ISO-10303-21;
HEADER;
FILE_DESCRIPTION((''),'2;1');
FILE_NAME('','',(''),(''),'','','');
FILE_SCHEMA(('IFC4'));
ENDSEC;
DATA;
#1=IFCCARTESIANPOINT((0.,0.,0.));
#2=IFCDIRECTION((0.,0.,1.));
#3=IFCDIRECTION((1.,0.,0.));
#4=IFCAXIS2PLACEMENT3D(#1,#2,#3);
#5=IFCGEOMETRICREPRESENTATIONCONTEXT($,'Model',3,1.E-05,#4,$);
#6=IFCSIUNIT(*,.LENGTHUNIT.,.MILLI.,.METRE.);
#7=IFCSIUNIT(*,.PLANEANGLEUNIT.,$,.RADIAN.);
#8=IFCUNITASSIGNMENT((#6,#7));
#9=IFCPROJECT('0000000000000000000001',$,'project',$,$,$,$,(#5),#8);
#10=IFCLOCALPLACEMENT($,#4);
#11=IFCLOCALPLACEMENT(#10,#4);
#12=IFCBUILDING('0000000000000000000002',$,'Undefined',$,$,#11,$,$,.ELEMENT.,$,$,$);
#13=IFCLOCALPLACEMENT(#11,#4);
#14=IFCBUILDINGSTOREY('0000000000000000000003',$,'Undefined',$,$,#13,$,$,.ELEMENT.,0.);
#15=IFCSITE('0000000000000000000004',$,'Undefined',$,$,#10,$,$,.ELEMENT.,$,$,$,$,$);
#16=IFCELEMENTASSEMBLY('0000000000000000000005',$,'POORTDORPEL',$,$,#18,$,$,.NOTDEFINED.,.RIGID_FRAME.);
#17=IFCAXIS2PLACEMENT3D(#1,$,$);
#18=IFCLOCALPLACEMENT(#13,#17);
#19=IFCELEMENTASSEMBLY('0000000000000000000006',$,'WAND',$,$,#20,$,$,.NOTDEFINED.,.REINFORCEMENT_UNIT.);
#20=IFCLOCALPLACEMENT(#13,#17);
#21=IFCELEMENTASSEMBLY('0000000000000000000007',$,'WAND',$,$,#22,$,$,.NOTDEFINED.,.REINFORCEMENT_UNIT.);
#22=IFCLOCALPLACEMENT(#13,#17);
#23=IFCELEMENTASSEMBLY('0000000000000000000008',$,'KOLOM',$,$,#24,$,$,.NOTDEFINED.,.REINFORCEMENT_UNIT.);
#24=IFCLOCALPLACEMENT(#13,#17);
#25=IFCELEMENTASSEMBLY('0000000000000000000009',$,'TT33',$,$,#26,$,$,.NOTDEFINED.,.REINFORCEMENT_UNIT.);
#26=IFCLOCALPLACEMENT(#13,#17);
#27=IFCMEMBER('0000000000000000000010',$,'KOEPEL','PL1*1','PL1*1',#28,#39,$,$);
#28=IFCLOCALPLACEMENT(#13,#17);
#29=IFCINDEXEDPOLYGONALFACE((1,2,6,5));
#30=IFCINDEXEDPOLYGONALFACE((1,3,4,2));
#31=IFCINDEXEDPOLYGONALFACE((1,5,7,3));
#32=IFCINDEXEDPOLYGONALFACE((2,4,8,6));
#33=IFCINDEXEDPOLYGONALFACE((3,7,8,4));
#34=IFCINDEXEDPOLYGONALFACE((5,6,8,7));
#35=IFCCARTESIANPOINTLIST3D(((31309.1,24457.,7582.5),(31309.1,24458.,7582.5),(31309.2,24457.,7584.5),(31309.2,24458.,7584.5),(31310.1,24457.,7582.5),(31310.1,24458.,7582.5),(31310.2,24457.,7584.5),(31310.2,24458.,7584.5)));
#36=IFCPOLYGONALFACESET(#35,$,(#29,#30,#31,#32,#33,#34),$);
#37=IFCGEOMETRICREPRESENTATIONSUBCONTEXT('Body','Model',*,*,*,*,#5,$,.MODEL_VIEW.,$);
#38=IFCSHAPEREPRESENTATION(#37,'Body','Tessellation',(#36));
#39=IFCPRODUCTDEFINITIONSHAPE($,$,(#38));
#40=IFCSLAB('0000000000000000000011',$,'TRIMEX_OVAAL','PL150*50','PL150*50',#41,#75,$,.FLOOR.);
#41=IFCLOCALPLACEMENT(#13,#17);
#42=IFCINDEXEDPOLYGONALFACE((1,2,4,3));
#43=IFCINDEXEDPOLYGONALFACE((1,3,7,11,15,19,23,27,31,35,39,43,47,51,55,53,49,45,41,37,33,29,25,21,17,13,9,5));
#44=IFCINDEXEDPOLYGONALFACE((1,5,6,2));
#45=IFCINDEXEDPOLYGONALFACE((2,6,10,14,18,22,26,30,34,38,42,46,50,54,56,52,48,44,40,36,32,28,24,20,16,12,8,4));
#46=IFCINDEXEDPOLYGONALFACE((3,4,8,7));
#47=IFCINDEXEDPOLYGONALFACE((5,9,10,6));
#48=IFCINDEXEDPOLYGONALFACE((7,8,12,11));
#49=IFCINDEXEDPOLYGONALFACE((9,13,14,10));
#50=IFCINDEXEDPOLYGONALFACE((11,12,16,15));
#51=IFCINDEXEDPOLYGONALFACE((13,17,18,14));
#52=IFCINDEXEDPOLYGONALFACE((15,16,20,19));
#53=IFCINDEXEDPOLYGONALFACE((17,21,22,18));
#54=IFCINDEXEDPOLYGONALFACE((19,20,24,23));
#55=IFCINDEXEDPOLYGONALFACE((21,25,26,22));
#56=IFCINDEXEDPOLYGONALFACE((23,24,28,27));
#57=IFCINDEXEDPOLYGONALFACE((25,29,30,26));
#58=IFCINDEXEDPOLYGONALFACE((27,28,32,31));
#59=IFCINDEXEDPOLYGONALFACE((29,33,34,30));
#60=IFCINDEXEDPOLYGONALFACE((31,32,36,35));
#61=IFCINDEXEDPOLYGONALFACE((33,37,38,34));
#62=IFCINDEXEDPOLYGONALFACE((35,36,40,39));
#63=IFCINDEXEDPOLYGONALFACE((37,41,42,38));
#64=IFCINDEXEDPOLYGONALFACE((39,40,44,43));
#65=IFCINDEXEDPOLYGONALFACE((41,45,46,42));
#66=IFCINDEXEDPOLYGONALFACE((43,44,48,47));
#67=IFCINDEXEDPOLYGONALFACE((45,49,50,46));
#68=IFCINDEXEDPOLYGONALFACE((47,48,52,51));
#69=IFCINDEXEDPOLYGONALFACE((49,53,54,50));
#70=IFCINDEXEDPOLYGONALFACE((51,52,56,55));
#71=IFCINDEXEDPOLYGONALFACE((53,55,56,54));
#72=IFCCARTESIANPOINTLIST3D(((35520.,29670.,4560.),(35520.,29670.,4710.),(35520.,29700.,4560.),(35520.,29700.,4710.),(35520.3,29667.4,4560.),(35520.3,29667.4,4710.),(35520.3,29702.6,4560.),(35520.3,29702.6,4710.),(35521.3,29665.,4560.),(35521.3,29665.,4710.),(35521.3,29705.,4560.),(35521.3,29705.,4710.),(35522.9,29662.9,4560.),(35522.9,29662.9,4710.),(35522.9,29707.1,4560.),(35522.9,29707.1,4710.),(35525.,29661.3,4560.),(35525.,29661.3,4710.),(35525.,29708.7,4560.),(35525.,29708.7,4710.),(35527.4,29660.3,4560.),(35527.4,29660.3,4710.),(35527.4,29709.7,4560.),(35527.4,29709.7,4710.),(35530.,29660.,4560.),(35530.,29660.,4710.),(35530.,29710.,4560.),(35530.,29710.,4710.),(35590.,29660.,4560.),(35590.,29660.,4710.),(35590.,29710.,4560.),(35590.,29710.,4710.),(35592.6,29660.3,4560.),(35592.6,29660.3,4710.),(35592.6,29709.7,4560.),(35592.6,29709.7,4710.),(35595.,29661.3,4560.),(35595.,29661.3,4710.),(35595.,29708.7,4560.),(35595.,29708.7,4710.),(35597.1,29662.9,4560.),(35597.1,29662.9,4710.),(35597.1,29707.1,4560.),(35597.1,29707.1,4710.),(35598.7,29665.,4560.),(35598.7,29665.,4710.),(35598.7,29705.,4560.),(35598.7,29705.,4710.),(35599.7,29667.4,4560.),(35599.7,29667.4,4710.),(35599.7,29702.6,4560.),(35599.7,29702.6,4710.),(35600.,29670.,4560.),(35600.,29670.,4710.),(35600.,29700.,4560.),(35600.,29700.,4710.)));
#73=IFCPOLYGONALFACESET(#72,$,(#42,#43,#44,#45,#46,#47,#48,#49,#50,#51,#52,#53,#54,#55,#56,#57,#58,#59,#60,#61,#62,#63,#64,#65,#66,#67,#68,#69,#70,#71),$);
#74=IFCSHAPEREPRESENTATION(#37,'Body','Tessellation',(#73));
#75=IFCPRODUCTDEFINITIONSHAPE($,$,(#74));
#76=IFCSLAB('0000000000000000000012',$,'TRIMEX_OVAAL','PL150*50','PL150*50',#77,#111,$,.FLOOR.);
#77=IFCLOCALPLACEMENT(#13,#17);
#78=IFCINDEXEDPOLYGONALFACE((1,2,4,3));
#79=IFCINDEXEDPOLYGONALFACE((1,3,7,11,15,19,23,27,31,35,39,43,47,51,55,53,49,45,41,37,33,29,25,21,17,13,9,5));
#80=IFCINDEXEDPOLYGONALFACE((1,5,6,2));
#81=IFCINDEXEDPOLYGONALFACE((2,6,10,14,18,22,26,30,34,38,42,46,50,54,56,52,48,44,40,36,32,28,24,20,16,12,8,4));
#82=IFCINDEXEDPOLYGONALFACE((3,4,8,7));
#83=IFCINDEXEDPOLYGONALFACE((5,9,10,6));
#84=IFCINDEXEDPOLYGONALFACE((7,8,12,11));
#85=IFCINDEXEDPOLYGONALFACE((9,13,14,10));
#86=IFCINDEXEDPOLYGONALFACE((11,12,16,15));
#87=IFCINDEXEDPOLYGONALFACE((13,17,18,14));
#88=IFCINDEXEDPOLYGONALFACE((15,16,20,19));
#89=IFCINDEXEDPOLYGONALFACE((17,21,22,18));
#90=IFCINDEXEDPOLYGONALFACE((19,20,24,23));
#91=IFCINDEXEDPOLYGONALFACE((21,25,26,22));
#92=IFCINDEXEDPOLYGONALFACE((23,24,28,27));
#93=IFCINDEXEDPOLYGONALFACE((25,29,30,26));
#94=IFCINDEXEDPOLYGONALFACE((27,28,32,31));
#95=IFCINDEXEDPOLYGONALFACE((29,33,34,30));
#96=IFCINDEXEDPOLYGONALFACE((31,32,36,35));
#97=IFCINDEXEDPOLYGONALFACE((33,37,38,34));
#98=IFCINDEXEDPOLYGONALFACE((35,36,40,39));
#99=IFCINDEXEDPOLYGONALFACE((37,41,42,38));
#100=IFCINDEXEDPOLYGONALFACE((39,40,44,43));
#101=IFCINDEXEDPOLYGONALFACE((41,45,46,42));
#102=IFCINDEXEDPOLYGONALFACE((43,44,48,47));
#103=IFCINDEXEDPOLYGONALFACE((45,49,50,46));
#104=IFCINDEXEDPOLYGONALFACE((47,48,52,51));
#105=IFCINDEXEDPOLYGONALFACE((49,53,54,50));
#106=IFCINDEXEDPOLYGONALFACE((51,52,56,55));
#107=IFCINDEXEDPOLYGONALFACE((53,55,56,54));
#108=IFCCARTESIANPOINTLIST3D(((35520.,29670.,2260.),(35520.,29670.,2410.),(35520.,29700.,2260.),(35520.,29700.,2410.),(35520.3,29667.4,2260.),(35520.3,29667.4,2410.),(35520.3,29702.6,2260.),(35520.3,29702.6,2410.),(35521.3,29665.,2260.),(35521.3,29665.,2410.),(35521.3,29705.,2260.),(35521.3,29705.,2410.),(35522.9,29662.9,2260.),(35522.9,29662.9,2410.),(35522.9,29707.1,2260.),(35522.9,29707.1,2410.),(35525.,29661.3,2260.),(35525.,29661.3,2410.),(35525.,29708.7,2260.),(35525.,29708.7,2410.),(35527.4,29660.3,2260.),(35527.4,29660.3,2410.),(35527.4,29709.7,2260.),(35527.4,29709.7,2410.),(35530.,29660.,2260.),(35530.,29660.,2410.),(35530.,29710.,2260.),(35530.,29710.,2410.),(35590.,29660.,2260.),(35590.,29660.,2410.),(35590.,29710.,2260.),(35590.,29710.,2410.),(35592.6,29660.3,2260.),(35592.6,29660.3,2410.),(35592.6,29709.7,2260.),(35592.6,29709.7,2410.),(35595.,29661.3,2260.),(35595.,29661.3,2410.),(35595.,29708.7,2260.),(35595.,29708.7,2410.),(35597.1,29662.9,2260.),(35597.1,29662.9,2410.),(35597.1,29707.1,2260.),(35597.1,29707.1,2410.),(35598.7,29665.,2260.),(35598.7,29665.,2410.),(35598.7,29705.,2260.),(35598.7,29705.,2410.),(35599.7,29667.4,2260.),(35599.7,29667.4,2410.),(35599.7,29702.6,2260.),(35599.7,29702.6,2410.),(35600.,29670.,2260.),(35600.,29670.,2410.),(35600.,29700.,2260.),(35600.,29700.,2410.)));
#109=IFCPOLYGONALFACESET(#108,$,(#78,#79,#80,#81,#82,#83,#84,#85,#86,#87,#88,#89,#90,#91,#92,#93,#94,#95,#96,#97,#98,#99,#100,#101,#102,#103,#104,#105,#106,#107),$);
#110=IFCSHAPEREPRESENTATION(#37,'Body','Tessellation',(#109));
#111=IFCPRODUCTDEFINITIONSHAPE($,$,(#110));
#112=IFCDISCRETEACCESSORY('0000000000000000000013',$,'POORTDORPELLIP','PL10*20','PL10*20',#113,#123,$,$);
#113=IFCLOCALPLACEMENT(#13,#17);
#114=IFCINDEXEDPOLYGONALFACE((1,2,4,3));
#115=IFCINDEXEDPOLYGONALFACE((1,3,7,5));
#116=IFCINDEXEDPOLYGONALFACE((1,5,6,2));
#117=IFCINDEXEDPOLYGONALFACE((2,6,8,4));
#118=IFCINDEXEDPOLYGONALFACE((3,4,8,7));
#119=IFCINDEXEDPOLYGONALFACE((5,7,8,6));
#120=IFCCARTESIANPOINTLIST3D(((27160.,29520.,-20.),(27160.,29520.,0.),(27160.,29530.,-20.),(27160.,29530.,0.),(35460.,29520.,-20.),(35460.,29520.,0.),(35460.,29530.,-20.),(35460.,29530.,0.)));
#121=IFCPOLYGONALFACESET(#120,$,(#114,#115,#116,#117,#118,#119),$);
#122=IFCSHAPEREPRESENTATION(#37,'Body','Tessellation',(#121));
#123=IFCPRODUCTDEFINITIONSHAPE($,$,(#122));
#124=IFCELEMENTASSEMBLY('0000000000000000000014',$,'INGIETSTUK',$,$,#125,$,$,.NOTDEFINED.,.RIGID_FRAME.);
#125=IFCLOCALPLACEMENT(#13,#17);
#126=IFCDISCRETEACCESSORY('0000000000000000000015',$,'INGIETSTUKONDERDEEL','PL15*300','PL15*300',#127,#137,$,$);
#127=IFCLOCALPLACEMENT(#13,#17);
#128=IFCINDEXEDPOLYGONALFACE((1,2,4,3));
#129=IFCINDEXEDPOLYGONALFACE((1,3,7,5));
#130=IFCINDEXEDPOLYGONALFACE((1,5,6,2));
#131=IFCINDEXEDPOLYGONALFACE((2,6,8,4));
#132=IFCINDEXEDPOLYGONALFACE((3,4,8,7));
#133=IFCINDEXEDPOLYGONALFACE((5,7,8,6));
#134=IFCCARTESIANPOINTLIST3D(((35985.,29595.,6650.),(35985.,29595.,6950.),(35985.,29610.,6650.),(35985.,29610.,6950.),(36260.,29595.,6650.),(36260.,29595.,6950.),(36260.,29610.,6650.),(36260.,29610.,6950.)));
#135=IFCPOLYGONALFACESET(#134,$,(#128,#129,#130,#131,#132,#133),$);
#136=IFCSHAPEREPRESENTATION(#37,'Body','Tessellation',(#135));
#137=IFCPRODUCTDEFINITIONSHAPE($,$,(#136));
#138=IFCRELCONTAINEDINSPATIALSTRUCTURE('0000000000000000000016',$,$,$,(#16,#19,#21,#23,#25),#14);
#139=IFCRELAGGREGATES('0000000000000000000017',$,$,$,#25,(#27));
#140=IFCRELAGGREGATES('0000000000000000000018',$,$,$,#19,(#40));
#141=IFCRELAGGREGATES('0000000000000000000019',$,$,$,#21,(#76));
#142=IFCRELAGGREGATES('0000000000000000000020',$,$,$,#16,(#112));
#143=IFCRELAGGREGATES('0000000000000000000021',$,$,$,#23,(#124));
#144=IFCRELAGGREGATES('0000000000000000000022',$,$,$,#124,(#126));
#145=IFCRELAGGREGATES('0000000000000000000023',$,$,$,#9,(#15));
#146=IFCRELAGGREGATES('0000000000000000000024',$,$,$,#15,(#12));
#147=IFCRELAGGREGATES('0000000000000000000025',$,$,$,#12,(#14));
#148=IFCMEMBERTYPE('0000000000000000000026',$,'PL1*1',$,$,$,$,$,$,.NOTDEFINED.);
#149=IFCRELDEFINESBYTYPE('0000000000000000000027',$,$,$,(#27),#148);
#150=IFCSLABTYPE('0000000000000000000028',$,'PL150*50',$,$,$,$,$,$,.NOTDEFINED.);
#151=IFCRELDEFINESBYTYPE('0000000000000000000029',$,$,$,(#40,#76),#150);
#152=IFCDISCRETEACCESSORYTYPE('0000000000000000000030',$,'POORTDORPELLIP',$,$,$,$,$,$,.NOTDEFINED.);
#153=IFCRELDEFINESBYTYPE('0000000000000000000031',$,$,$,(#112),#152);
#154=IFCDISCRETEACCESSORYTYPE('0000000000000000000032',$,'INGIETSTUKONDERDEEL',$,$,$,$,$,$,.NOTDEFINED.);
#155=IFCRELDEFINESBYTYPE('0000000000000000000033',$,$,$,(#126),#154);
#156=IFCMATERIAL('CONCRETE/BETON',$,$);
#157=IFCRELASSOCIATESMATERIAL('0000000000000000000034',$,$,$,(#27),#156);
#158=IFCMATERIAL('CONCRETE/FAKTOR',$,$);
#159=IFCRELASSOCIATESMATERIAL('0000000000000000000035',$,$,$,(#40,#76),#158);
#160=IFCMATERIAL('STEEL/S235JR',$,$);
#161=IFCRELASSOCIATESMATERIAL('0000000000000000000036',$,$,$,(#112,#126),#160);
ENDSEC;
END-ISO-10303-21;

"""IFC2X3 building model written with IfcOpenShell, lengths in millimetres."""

from ifc_helpers import new_model, si_unit, frame, frame_2d, origin_with_axes, place, context, subcontext, project, spatial, polyline, circle_curve, parameter, trimmed, segment, composite_curve, rectangle, outline, extrude, material, type_object, element, aggregate, save


model = new_model("IFC2X3")

# Units and contexts
model_context = context("Model", 3, precision=1e-05, world=origin_with_axes())
body_context = subcontext(model_context, "Body", "Model", "MODEL_VIEW")
ifc_project = project(units=[si_unit("LENGTHUNIT", "METRE", prefix="MILLI"), si_unit("PLANEANGLEUNIT", "RADIAN")], contexts=[model_context])

# Site, building, storey
site_placement = place(None, origin_with_axes())
site = spatial("IfcSite", under=ifc_project, at=site_placement, Name="Undefined", CompositionType="ELEMENT")
building_placement = place(site_placement, origin_with_axes())
building = spatial("IfcBuilding", under=site, at=building_placement, Name="Undefined", CompositionType="ELEMENT")
storey_placement = place(building_placement, origin_with_axes())
storey = spatial("IfcBuildingStorey", under=building, at=storey_placement, Name="Undefined", CompositionType="ELEMENT", Elevation=0.0)

# Element assembly
assembly_1_placement = place(storey_placement, origin_with_axes())
assembly_1 = element("IfcElementAssembly", 1, at=assembly_1_placement, inside=storey, Name="POORTDORPEL", AssemblyPlace="NOTDEFINED", PredefinedType="RIGID_FRAME")
ifc_material_1 = material(Name="STEEL/S235JR")

# Shared definitions
ifc_material_2 = material(Name="CONCRETE/BETON")

# Element assemblies
assembly_2_placement = place(storey_placement, origin_with_axes())
assembly_2 = element("IfcElementAssembly", 2, at=assembly_2_placement, inside=storey, Name="WAND", AssemblyPlace="NOTDEFINED", PredefinedType="REINFORCEMENT_UNIT")
assembly_3_placement = place(storey_placement, origin_with_axes())
assembly_3 = element("IfcElementAssembly", 3, at=assembly_3_placement, inside=storey, Name="WAND", AssemblyPlace="NOTDEFINED", PredefinedType="REINFORCEMENT_UNIT")
ifc_material_3 = material(Name="CONCRETE/FAKTOR")

# Element assembly
assembly_4_placement = place(storey_placement, origin_with_axes())
assembly_4 = element("IfcElementAssembly", 4, at=assembly_4_placement, inside=storey, Name="KOLOM", AssemblyPlace="NOTDEFINED", PredefinedType="REINFORCEMENT_UNIT")

# Element assembly, member
assembly_5_placement = place(storey_placement, origin_with_axes())
assembly_5 = element("IfcElementAssembly", 5, at=assembly_5_placement, inside=storey, Name="TT33", AssemblyPlace="NOTDEFINED", PredefinedType="REINFORCEMENT_UNIT")
member_type = type_object("IfcMemberType", Name="PL1*1", PredefinedType="NOTDEFINED")
member_placement = place(assembly_5_placement, frame((31309.6, 24457.5, 7582.5), z_axis=(-0.999516, 0.0, 0.031107), x_axis=(0.031107, 0.0, 0.999516)))
member = element("IfcMember", 6, at=member_placement, type_object=member_type, material=ifc_material_2, Name="KOEPEL", Description="PL1*1", ObjectType="PL1*1", context=body_context, shape_type="SweptSolid", body=[
    extrude(rectangle(XDim=1.0, YDim=1.0, at=frame_2d((0.0, 0.0), x_axis=(1.0, 0.0))), frame((2.0, 0.0, 0.0), z_axis=(-1.0, 0.0, 0.0), x_axis=(0.0, -1.0, 0.0)), (0.0, 0.0, 1.0), 2.0),
])
aggregate(assembly_5, [member])

# Slabs
slab_type = type_object("IfcSlabType", Name="PL150*50", PredefinedType="NOTDEFINED")
slab_1_placement = place(assembly_2_placement, frame((35600.0, 29660.0, 4635.0), z_axis=(0.0, 0.0, 1.0), x_axis=(0.0, 1.0, 0.0)))
slab_1 = element("IfcSlab", 7, at=slab_1_placement, type_object=slab_type, material=ifc_material_3, Name="TRIMEX_OVAAL", Description="PL150*50", ObjectType="PL150*50", PredefinedType="FLOOR", context=body_context, shape_type="SweptSolid", body=[
    extrude(outline(composite_curve([segment(trimmed(circle_curve(frame_2d((10.0, 10.0), x_axis=(-1.0, 0.0)), 10.0), [parameter(0.0)], [parameter(1.570796)], True, "PARAMETER"), True, "CONTINUOUS"), segment(polyline([(10.0, 0.0), (40.0, 0.0)]), True, "CONTINUOUS"), segment(trimmed(circle_curve(frame_2d((40.0, 10.0), x_axis=(0.0, -1.0)), 10.0), [parameter(0.0)], [parameter(1.570796)], True, "PARAMETER"), True, "CONTINUOUS"), segment(polyline([(50.0, 10.0), (50.0, 70.0)]), True, "CONTINUOUS"), segment(trimmed(circle_curve(frame_2d((40.0, 70.0), x_axis=(1.0, 0.0)), 10.0), [parameter(0.0)], [parameter(1.570796)], True, "PARAMETER"), True, "CONTINUOUS"), segment(polyline([(40.0, 80.0), (10.0, 80.0)]), True, "CONTINUOUS"), segment(trimmed(circle_curve(frame_2d((10.0, 70.0), x_axis=(0.0, 1.0)), 10.0), [parameter(0.0)], [parameter(1.570796)], True, "PARAMETER"), True, "CONTINUOUS"), segment(polyline([(0.0, 70.0), (0.0, 10.0)]), True, "CONTINUOUS")], self_intersect=True)), frame((0.0, 0.0, -75.0), z_axis=(0.0, 0.0, 1.0), x_axis=(1.0, 0.0, 0.0)), (0.0, 0.0, 1.0), 150.0),
])
aggregate(assembly_2, [slab_1])
slab_2_placement = place(assembly_3_placement, frame((35600.0, 29660.0, 2335.0), z_axis=(0.0, 0.0, 1.0), x_axis=(0.0, 1.0, 0.0)))
slab_2 = element("IfcSlab", 8, at=slab_2_placement, type_object=slab_type, material=ifc_material_3, Name="TRIMEX_OVAAL", Description="PL150*50", ObjectType="PL150*50", PredefinedType="FLOOR", context=body_context, shape_type="SweptSolid", body=[
    extrude(outline(composite_curve([segment(trimmed(circle_curve(frame_2d((10.0, 10.0), x_axis=(-1.0, 0.0)), 10.0), [parameter(0.0)], [parameter(1.570796)], True, "PARAMETER"), True, "CONTINUOUS"), segment(polyline([(10.0, 0.0), (40.0, 0.0)]), True, "CONTINUOUS"), segment(trimmed(circle_curve(frame_2d((40.0, 10.0), x_axis=(0.0, -1.0)), 10.0), [parameter(0.0)], [parameter(1.570796)], True, "PARAMETER"), True, "CONTINUOUS"), segment(polyline([(50.0, 10.0), (50.0, 70.0)]), True, "CONTINUOUS"), segment(trimmed(circle_curve(frame_2d((40.0, 70.0), x_axis=(1.0, 0.0)), 10.0), [parameter(0.0)], [parameter(1.570796)], True, "PARAMETER"), True, "CONTINUOUS"), segment(polyline([(40.0, 80.0), (10.0, 80.0)]), True, "CONTINUOUS"), segment(trimmed(circle_curve(frame_2d((10.0, 70.0), x_axis=(0.0, 1.0)), 10.0), [parameter(0.0)], [parameter(1.570796)], True, "PARAMETER"), True, "CONTINUOUS"), segment(polyline([(0.0, 70.0), (0.0, 10.0)]), True, "CONTINUOUS")], self_intersect=True)), frame((0.0, 0.0, -75.0), z_axis=(0.0, 0.0, 1.0), x_axis=(1.0, 0.0, 0.0)), (0.0, 0.0, 1.0), 150.0),
])
aggregate(assembly_3, [slab_2])

# Discrete accessory
discrete_accessory_type_1 = type_object("IfcDiscreteAccessoryType", Name="POORTDORPELLIP")
discrete_accessory_1_placement = place(assembly_1_placement, frame((35460.0, 29525.0, -10.0), z_axis=(0.0, 0.0, -1.0), x_axis=(-1.0, 0.0, 0.0)))
discrete_accessory_1 = element("IfcDiscreteAccessory", 9, at=discrete_accessory_1_placement, type_object=discrete_accessory_type_1, material=ifc_material_1, Name="POORTDORPELLIP", Description="PL10*20", ObjectType="PL10*20", context=body_context, shape_type="SweptSolid", body=[
    extrude(rectangle(XDim=10.0, YDim=20.0, at=frame_2d((0.0, 0.0), x_axis=(1.0, 0.0))), frame((8300.0, 0.0, 0.0), z_axis=(-1.0, 0.0, 0.0), x_axis=(0.0, -1.0, 0.0)), (0.0, 0.0, 1.0), 8300.0),
])
aggregate(assembly_1, [discrete_accessory_1])

# Element assembly
assembly_6_placement = place(assembly_4_placement, origin_with_axes())
assembly_6 = element("IfcElementAssembly", 10, at=assembly_6_placement, Name="INGIETSTUK", AssemblyPlace="NOTDEFINED", PredefinedType="RIGID_FRAME")
aggregate(assembly_4, [assembly_6])

# Discrete accessory
discrete_accessory_type_2 = type_object("IfcDiscreteAccessoryType", Name="INGIETSTUKONDERDEEL")
discrete_accessory_2_placement = place(assembly_6_placement, frame((35985.0, 29602.5, 6800.0), z_axis=(0.0, 0.0, -1.0), x_axis=(1.0, 0.0, 0.0)))
discrete_accessory_2 = element("IfcDiscreteAccessory", 11, at=discrete_accessory_2_placement, type_object=discrete_accessory_type_2, material=ifc_material_1, Name="INGIETSTUKONDERDEEL", Description="PL15*300", ObjectType="PL15*300", context=body_context, shape_type="SweptSolid", body=[
    extrude(rectangle(XDim=15.0, YDim=300.0, at=frame_2d((0.0, 0.0), x_axis=(1.0, 0.0))), frame((275.0, 0.0, 0.0), z_axis=(-1.0, 0.0, 0.0), x_axis=(0.0, -1.0, 0.0)), (0.0, 0.0, 1.0), 275.0),
])
aggregate(assembly_6, [discrete_accessory_2])

save(model, "model.ifc")
